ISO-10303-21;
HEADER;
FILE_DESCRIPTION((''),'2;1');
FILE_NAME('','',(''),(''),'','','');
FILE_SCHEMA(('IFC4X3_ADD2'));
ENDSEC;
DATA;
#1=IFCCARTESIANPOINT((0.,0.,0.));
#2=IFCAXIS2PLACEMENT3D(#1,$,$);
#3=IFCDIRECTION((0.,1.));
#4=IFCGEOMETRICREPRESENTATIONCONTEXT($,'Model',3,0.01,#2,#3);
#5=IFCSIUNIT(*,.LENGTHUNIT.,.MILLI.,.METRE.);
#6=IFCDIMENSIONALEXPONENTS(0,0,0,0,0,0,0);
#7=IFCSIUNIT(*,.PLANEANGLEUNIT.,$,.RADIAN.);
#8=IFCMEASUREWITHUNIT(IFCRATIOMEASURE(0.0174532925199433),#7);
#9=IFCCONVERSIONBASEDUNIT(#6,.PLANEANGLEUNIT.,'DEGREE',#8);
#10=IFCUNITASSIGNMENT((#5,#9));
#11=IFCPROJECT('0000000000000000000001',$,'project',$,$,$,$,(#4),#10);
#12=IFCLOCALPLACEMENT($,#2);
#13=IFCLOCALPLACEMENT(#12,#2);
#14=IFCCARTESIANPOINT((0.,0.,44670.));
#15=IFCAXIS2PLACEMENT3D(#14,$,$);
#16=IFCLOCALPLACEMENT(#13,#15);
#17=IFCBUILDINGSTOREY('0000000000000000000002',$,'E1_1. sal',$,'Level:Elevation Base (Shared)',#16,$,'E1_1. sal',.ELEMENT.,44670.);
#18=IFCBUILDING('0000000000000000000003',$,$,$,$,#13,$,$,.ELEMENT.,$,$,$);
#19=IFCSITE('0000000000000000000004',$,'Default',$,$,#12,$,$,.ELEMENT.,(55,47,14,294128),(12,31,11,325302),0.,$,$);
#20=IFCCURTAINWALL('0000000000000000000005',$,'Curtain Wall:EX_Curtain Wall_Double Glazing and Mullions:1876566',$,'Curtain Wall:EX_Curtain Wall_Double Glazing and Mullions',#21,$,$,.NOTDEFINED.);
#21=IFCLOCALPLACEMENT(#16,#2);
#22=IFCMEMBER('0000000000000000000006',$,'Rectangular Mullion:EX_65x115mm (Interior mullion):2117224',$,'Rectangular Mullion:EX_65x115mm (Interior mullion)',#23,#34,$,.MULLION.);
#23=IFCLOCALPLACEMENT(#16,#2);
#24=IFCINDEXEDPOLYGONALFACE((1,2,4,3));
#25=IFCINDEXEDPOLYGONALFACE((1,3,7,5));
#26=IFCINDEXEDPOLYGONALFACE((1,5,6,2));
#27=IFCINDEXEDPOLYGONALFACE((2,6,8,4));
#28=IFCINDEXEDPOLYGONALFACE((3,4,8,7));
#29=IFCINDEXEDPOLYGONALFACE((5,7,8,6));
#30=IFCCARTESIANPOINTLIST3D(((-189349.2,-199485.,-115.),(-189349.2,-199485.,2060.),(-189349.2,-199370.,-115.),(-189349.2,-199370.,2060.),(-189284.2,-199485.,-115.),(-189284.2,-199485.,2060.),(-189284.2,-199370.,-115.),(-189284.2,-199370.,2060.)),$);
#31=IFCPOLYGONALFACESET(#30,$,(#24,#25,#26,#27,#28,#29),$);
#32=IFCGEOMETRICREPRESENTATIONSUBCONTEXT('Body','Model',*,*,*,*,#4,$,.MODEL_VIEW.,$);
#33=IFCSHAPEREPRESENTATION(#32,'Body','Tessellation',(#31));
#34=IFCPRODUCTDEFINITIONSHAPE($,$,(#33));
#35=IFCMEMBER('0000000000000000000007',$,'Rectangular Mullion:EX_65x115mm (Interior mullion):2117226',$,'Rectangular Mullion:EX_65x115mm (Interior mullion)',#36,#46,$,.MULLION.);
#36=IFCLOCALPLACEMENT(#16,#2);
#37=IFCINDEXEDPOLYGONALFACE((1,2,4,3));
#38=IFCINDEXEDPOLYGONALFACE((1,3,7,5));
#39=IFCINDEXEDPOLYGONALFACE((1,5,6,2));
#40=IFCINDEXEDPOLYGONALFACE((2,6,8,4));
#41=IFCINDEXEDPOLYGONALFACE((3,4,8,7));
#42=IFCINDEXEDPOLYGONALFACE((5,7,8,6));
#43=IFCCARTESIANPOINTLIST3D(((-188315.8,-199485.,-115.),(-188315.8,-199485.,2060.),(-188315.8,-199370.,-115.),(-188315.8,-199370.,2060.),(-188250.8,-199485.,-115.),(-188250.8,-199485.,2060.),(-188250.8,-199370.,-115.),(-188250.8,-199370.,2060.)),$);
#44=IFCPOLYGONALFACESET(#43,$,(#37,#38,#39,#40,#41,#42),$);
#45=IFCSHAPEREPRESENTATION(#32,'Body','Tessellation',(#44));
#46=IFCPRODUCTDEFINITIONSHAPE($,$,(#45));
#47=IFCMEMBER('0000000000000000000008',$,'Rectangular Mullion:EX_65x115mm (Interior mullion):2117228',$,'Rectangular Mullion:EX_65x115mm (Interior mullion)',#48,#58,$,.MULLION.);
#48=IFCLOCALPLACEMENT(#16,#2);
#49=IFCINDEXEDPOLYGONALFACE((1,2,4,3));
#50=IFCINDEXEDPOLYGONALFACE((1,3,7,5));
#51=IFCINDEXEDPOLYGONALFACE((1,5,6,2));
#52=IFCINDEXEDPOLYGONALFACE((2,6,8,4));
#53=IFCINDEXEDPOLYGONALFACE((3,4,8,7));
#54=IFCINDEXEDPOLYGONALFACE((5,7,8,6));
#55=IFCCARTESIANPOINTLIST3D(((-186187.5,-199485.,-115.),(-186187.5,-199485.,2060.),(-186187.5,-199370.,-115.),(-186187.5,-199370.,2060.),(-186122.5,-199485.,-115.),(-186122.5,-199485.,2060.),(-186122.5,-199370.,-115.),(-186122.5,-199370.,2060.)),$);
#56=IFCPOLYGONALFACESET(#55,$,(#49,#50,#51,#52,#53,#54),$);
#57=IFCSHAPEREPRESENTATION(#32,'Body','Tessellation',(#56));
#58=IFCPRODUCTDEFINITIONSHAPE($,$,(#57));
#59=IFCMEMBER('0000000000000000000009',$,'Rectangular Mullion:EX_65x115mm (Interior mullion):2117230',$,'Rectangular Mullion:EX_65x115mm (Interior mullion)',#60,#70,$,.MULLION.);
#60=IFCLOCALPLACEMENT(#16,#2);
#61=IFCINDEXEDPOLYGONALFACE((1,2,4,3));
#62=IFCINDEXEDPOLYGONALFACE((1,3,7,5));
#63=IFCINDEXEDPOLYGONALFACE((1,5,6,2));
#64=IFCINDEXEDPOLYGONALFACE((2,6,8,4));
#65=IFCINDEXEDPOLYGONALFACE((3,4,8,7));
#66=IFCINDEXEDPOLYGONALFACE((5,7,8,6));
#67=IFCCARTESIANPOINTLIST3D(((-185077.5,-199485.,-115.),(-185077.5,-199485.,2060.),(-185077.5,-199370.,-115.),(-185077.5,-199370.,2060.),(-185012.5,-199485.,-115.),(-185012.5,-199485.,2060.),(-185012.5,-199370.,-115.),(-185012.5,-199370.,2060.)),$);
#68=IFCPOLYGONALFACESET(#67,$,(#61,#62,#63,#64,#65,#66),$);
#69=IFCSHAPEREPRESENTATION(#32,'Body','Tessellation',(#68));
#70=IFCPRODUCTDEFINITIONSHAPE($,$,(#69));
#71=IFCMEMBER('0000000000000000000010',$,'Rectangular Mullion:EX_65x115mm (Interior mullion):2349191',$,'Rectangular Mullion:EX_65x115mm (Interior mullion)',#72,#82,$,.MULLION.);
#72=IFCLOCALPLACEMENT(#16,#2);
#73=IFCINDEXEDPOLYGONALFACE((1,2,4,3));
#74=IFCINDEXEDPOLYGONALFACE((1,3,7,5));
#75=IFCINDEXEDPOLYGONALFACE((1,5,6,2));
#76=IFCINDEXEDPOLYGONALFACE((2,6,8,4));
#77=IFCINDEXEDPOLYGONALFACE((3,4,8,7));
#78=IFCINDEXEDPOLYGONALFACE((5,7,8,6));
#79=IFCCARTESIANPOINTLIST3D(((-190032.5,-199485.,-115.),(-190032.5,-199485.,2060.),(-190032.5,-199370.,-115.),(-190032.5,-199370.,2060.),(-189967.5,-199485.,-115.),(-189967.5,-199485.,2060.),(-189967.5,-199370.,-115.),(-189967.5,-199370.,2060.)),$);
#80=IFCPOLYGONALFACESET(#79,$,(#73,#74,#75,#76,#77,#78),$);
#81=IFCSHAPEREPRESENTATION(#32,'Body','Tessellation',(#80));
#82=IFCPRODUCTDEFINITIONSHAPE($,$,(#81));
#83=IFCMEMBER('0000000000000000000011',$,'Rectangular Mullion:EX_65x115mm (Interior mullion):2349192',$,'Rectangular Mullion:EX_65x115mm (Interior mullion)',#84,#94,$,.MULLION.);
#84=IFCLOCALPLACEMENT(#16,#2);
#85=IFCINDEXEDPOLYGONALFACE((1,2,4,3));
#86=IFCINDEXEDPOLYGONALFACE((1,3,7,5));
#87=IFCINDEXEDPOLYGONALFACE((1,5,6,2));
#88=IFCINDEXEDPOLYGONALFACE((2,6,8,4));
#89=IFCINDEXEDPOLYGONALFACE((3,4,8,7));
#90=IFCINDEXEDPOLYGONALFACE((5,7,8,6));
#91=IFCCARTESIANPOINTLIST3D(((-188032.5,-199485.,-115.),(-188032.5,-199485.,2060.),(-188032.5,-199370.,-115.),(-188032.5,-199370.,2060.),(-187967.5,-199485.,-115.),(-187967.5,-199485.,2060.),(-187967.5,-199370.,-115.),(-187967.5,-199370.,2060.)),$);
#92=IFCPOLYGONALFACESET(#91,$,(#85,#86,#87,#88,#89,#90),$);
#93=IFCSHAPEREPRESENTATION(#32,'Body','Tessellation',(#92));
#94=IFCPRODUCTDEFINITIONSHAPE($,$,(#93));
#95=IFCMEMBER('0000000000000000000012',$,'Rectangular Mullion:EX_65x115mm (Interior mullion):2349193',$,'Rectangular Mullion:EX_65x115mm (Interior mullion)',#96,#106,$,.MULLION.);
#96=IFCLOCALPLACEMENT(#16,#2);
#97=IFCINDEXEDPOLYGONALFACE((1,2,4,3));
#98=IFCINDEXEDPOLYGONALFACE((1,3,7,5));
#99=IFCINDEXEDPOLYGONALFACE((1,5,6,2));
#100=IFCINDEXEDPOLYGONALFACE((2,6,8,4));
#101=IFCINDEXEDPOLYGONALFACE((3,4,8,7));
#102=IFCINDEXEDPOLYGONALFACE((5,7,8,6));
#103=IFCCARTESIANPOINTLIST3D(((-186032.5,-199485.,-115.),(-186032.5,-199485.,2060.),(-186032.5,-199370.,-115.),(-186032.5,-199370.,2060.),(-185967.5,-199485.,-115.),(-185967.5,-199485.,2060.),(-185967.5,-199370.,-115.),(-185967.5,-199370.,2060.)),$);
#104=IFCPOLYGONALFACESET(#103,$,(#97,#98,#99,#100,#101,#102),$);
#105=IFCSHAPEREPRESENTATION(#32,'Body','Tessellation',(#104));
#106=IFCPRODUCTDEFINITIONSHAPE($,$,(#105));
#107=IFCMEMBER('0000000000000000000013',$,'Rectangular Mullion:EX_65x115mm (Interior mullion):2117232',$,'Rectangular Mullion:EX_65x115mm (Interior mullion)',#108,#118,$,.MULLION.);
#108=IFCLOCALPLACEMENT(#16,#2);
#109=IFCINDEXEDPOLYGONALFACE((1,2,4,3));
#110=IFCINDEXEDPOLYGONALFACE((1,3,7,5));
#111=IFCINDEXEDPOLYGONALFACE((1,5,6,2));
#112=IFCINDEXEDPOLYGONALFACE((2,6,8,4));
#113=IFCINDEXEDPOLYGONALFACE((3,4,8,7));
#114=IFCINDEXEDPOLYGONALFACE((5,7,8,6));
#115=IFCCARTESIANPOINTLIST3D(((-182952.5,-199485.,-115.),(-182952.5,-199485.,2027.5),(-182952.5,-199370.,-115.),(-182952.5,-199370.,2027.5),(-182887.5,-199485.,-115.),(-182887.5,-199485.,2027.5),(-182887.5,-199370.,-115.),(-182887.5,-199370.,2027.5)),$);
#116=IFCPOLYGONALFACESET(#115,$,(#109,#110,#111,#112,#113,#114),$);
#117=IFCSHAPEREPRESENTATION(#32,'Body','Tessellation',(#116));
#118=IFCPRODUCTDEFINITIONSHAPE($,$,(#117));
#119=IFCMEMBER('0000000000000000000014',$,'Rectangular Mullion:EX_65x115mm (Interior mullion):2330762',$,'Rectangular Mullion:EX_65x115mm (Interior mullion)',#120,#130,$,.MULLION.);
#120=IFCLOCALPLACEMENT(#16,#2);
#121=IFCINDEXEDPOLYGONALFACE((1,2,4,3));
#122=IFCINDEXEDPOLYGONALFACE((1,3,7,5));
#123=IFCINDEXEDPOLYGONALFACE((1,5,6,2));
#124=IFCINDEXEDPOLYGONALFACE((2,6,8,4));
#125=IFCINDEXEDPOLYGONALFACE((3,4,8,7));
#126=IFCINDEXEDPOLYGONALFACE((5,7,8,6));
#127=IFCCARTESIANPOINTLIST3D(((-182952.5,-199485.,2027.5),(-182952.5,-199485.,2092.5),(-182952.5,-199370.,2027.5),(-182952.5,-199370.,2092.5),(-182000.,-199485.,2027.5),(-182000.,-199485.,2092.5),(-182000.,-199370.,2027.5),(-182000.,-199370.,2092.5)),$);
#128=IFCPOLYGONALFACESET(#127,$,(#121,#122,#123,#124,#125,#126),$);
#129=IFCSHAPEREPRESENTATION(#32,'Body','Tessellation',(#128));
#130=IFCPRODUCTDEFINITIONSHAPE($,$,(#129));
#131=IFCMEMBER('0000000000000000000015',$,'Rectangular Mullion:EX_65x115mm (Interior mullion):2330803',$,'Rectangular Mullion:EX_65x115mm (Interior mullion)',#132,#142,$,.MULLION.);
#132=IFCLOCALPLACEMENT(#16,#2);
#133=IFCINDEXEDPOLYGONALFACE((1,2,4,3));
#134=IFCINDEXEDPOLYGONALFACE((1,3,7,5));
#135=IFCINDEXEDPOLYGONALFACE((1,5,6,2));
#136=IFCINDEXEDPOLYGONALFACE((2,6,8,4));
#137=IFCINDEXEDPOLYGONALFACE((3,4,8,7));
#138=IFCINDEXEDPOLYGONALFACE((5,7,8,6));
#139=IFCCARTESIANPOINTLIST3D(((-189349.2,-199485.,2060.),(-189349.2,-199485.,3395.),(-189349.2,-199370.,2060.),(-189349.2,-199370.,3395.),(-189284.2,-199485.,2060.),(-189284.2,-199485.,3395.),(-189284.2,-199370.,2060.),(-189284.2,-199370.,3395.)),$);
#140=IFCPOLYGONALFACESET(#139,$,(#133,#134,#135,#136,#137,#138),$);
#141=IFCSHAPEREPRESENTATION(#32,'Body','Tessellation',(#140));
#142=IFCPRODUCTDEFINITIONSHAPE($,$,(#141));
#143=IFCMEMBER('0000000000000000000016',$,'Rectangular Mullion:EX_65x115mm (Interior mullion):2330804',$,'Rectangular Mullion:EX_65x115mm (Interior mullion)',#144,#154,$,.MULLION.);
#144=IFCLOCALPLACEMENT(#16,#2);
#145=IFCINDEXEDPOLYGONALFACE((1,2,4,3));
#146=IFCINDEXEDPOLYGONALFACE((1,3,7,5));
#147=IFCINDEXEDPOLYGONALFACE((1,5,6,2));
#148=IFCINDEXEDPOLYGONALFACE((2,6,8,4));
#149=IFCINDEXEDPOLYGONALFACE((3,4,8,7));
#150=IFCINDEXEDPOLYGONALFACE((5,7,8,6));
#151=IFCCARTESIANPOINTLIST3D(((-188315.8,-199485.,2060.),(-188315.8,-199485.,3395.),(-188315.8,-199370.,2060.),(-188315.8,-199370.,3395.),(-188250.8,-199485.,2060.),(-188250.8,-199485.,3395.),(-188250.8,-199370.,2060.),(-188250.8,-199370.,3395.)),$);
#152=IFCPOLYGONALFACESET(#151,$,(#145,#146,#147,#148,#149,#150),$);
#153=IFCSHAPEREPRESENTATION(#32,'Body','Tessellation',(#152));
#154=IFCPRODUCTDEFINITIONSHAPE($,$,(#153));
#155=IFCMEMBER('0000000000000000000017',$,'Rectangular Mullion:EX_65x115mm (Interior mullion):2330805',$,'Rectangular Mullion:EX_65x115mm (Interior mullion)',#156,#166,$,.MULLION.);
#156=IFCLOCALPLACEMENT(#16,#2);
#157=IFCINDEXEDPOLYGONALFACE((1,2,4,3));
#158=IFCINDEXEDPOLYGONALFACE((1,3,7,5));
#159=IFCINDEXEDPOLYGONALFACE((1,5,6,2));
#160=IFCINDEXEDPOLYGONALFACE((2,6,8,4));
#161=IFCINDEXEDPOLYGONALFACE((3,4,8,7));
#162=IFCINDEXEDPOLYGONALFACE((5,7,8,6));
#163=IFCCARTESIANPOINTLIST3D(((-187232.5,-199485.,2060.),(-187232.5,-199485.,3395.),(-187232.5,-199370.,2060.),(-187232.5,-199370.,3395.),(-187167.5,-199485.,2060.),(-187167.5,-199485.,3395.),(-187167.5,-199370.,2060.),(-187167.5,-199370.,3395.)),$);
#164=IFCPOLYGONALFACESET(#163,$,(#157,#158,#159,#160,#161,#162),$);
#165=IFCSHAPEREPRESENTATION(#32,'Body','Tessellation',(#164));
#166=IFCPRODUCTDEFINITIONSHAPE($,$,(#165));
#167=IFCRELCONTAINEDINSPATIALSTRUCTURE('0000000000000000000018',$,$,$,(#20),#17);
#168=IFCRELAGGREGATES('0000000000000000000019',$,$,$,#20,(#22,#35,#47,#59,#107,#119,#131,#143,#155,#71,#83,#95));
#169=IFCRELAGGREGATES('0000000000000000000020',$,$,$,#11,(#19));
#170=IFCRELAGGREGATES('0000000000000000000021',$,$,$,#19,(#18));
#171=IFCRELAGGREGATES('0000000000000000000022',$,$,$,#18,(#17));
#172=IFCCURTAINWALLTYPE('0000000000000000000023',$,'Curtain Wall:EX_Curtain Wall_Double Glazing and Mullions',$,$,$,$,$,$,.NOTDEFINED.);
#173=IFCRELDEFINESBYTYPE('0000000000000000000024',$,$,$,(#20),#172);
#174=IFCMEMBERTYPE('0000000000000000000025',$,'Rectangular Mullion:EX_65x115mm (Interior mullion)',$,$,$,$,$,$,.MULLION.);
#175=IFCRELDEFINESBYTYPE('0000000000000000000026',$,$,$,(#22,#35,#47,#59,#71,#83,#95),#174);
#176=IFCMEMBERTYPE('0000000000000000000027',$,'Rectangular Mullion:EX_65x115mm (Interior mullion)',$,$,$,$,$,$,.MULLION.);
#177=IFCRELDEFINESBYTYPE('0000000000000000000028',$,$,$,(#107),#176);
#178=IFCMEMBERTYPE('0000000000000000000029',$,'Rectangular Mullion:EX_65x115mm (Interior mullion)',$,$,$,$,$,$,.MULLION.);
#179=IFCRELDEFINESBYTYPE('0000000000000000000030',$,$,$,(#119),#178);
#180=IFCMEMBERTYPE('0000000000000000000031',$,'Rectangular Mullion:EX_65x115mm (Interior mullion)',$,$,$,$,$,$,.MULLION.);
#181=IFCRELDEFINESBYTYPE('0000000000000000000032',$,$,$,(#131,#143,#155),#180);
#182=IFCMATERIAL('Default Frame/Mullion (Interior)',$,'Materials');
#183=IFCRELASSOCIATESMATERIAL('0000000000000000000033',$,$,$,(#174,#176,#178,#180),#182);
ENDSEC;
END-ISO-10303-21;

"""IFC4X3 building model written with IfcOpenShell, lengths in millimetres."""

from ifc_helpers import new_model, entity, si_unit, converted_unit, direction, frame, origin, origin_2d_with_axis, place, context, subcontext, project, spatial, rectangle, extrude, source, transform, mapped, material, material_profile, profile_set, type_object, type_shapes, element, aggregate, save


model = new_model("IFC4X3")

# Units and contexts
model_context = context("Model", 3, precision=0.01, world=origin(), true_north=direction((0.0, 1.0)))
body_context = subcontext(model_context, "Body", "Model", "MODEL_VIEW")
ifc_project = project(units=[si_unit("LENGTHUNIT", "METRE", prefix="MILLI"), converted_unit("PLANEANGLEUNIT", "DEGREE", entity("IfcRatioMeasure", 0.0174532925199433), si_unit("PLANEANGLEUNIT", "RADIAN"), dimensions=[0, 0, 0, 0, 0, 0, 0])], contexts=[model_context])

# Site, building, storey
site_placement = place(None, origin())
site = spatial("IfcSite", under=ifc_project, at=site_placement, Name="Default", CompositionType="ELEMENT", RefLatitude=(55, 47, 14, 294128), RefLongitude=(12, 31, 11, 325302), RefElevation=0.0)
building_placement = place(site_placement, origin())
building = spatial("IfcBuilding", under=site, at=building_placement, CompositionType="ELEMENT")
storey_placement = place(building_placement, frame((0.0, 0.0, 44670.0)))
storey = spatial("IfcBuildingStorey", under=building, at=storey_placement, Name="E1_1. sal", ObjectType="Level:Elevation Base (Shared)", LongName="E1_1. sal", CompositionType="ELEMENT", Elevation=44670.0)

# Curtain wall, members
curtain_wall_type = type_object("IfcCurtainWallType", Name="Curtain Wall:EX_Curtain Wall_Double Glazing and Mullions", PredefinedType="NOTDEFINED")
curtain_wall_placement = place(storey_placement, frame((0.0, 0.0, -44670.0)))
curtain_wall = element("IfcCurtainWall", 1, at=curtain_wall_placement, inside=storey, type_object=curtain_wall_type, Name="Curtain Wall:EX_Curtain Wall_Double Glazing and Mullions:1876566", ObjectType="Curtain Wall:EX_Curtain Wall_Double Glazing and Mullions", PredefinedType="NOTDEFINED")
ifc_material_1 = material(Name="Default Frame/Mullion (Interior)", Category="Materials")
ifc_material_profile_1 = material_profile(ifc_material_1, rectangle(XDim=115.0, YDim=65.0, at=origin_2d_with_axis()), Name="EX_65x115mm (Interior mullion)")
ifc_profile_set_1 = profile_set([ifc_material_profile_1], Name="EX_65x115mm (Interior mullion)")
member_type_1 = type_object("IfcMemberType", Name="Rectangular Mullion:EX_65x115mm (Interior mullion)", PredefinedType="MULLION", material=ifc_profile_set_1)
shared_shape_1 = source(origin(), body_context, "Body", "SweptSolid", [
    extrude(rectangle(XDim=115.0, YDim=65.0, at=origin_2d_with_axis()), frame((0.0, -57.5, -2175.0), z_axis=(0.0, 0.0, 1.0), x_axis=(0.0, -1.0, 0.0)), (0.0, 0.0, 1.0), 2175.0),
])
type_shapes(member_type_1, [shared_shape_1])
member_1_placement = place(curtain_wall_placement, frame((-189316.7, -199485.0, 44555.0), z_axis=(0.0, 0.0, -1.0), x_axis=(1.0, 0.0, 0.0)))
member_1 = element("IfcMember", 2, at=member_1_placement, type_object=member_type_1, Name="Rectangular Mullion:EX_65x115mm (Interior mullion):2117224", ObjectType="Rectangular Mullion:EX_65x115mm (Interior mullion)", PredefinedType="MULLION", context=body_context, shape_type="MappedRepresentation", body=[
    mapped(shared_shape_1, transform((0.0, 0.0, 0.0), scale=1.0)),
])
member_2_placement = place(curtain_wall_placement, frame((-188283.3, -199485.0, 44555.0), z_axis=(0.0, 0.0, -1.0), x_axis=(1.0, 0.0, 0.0)))
member_2 = element("IfcMember", 3, at=member_2_placement, type_object=member_type_1, Name="Rectangular Mullion:EX_65x115mm (Interior mullion):2117226", ObjectType="Rectangular Mullion:EX_65x115mm (Interior mullion)", PredefinedType="MULLION", context=body_context, shape_type="MappedRepresentation", body=[
    mapped(shared_shape_1, transform((0.0, 0.0, 0.0), scale=1.0)),
])
member_3_placement = place(curtain_wall_placement, frame((-186155.0, -199485.0, 44555.0), z_axis=(0.0, 0.0, -1.0), x_axis=(1.0, 0.0, 0.0)))
member_3 = element("IfcMember", 4, at=member_3_placement, type_object=member_type_1, Name="Rectangular Mullion:EX_65x115mm (Interior mullion):2117228", ObjectType="Rectangular Mullion:EX_65x115mm (Interior mullion)", PredefinedType="MULLION", context=body_context, shape_type="MappedRepresentation", body=[
    mapped(shared_shape_1, transform((0.0, 0.0, 0.0), scale=1.0)),
])
member_4_placement = place(curtain_wall_placement, frame((-185045.0, -199485.0, 44555.0), z_axis=(0.0, 0.0, -1.0), x_axis=(1.0, 0.0, 0.0)))
member_4 = element("IfcMember", 5, at=member_4_placement, type_object=member_type_1, Name="Rectangular Mullion:EX_65x115mm (Interior mullion):2117230", ObjectType="Rectangular Mullion:EX_65x115mm (Interior mullion)", PredefinedType="MULLION", context=body_context, shape_type="MappedRepresentation", body=[
    mapped(shared_shape_1, transform((0.0, 0.0, 0.0), scale=1.0)),
])
member_5_placement = place(curtain_wall_placement, frame((-190000.0, -199485.0, 44555.0), z_axis=(0.0, 0.0, -1.0), x_axis=(1.0, 0.0, 0.0)))
member_5 = element("IfcMember", 6, at=member_5_placement, type_object=member_type_1, Name="Rectangular Mullion:EX_65x115mm (Interior mullion):2349191", ObjectType="Rectangular Mullion:EX_65x115mm (Interior mullion)", PredefinedType="MULLION", context=body_context, shape_type="MappedRepresentation", body=[
    mapped(shared_shape_1, transform((0.0, 0.0, 0.0), scale=1.0)),
])
member_6_placement = place(curtain_wall_placement, frame((-188000.0, -199485.0, 44555.0), z_axis=(0.0, 0.0, -1.0), x_axis=(1.0, 0.0, 0.0)))
member_6 = element("IfcMember", 7, at=member_6_placement, type_object=member_type_1, Name="Rectangular Mullion:EX_65x115mm (Interior mullion):2349192", ObjectType="Rectangular Mullion:EX_65x115mm (Interior mullion)", PredefinedType="MULLION", context=body_context, shape_type="MappedRepresentation", body=[
    mapped(shared_shape_1, transform((0.0, 0.0, 0.0), scale=1.0)),
])
member_7_placement = place(curtain_wall_placement, frame((-186000.0, -199485.0, 44555.0), z_axis=(0.0, 0.0, -1.0), x_axis=(1.0, 0.0, 0.0)))
member_7 = element("IfcMember", 8, at=member_7_placement, type_object=member_type_1, Name="Rectangular Mullion:EX_65x115mm (Interior mullion):2349193", ObjectType="Rectangular Mullion:EX_65x115mm (Interior mullion)", PredefinedType="MULLION", context=body_context, shape_type="MappedRepresentation", body=[
    mapped(shared_shape_1, transform((0.0, 0.0, 0.0), scale=1.0)),
])
member_type_2 = type_object("IfcMemberType", Name="Rectangular Mullion:EX_65x115mm (Interior mullion)", PredefinedType="MULLION", material=ifc_profile_set_1)
shared_shape_2 = source(origin(), body_context, "Body", "SweptSolid", [
    extrude(rectangle(XDim=115.0, YDim=65.0, at=origin_2d_with_axis()), frame((0.0, -57.5, -2142.5), z_axis=(0.0, 0.0, 1.0), x_axis=(0.0, -1.0, 0.0)), (0.0, 0.0, 1.0), 2142.5),
])
type_shapes(member_type_2, [shared_shape_2])
member_8_placement = place(curtain_wall_placement, frame((-182920.0, -199485.0, 44555.0), z_axis=(0.0, 0.0, -1.0), x_axis=(1.0, 0.0, 0.0)))
member_8 = element("IfcMember", 9, at=member_8_placement, type_object=member_type_2, Name="Rectangular Mullion:EX_65x115mm (Interior mullion):2117232", ObjectType="Rectangular Mullion:EX_65x115mm (Interior mullion)", PredefinedType="MULLION", context=body_context, shape_type="MappedRepresentation", body=[
    mapped(shared_shape_2, transform((0.0, 0.0, 0.0), scale=1.0)),
])
member_type_3 = type_object("IfcMemberType", Name="Rectangular Mullion:EX_65x115mm (Interior mullion)", PredefinedType="MULLION", material=ifc_profile_set_1)
shared_shape_3 = source(origin(), body_context, "Body", "SweptSolid", [
    extrude(rectangle(XDim=115.0, YDim=65.0, at=origin_2d_with_axis()), frame((0.0, -57.5, -952.5), z_axis=(0.0, 0.0, 1.0), x_axis=(0.0, -1.0, 0.0)), (0.0, 0.0, 1.0), 952.5),
])
type_shapes(member_type_3, [shared_shape_3])
member_9_placement = place(curtain_wall_placement, frame((-182000.0, -199485.0, 46730.0), z_axis=(1.0, 0.0, 0.0), x_axis=(0.0, 0.0, 1.0)))
member_9 = element("IfcMember", 10, at=member_9_placement, type_object=member_type_3, Name="Rectangular Mullion:EX_65x115mm (Interior mullion):2330762", ObjectType="Rectangular Mullion:EX_65x115mm (Interior mullion)", PredefinedType="MULLION", context=body_context, shape_type="MappedRepresentation", body=[
    mapped(shared_shape_3, transform((0.0, 0.0, 0.0), scale=1.0)),
])
member_type_4 = type_object("IfcMemberType", Name="Rectangular Mullion:EX_65x115mm (Interior mullion)", PredefinedType="MULLION", material=ifc_profile_set_1)
shared_shape_4 = source(origin(), body_context, "Body", "SweptSolid", [
    extrude(rectangle(XDim=115.0, YDim=65.0, at=origin_2d_with_axis()), frame((0.0, -57.5, -1335.0), z_axis=(0.0, 0.0, 1.0), x_axis=(0.0, -1.0, 0.0)), (0.0, 0.0, 1.0), 1335.0),
])
type_shapes(member_type_4, [shared_shape_4])
member_10_placement = place(curtain_wall_placement, frame((-189316.7, -199485.0, 46730.0), z_axis=(0.0, 0.0, -1.0), x_axis=(1.0, 0.0, 0.0)))
member_10 = element("IfcMember", 11, at=member_10_placement, type_object=member_type_4, Name="Rectangular Mullion:EX_65x115mm (Interior mullion):2330803", ObjectType="Rectangular Mullion:EX_65x115mm (Interior mullion)", PredefinedType="MULLION", context=body_context, shape_type="MappedRepresentation", body=[
    mapped(shared_shape_4, transform((0.0, 0.0, 0.0), scale=1.0)),
])
member_11_placement = place(curtain_wall_placement, frame((-188283.3, -199485.0, 46730.0), z_axis=(0.0, 0.0, -1.0), x_axis=(1.0, 0.0, 0.0)))
member_11 = element("IfcMember", 12, at=member_11_placement, type_object=member_type_4, Name="Rectangular Mullion:EX_65x115mm (Interior mullion):2330804", ObjectType="Rectangular Mullion:EX_65x115mm (Interior mullion)", PredefinedType="MULLION", context=body_context, shape_type="MappedRepresentation", body=[
    mapped(shared_shape_4, transform((0.0, 0.0, 0.0), scale=1.0)),
])
member_12_placement = place(curtain_wall_placement, frame((-187200.0, -199485.0, 46730.0), z_axis=(0.0, 0.0, -1.0), x_axis=(1.0, 0.0, 0.0)))
member_12 = element("IfcMember", 13, at=member_12_placement, type_object=member_type_4, Name="Rectangular Mullion:EX_65x115mm (Interior mullion):2330805", ObjectType="Rectangular Mullion:EX_65x115mm (Interior mullion)", PredefinedType="MULLION", context=body_context, shape_type="MappedRepresentation", body=[
    mapped(shared_shape_4, transform((0.0, 0.0, 0.0), scale=1.0)),
])
aggregate(curtain_wall, [member_1, member_2, member_3, member_4, member_8, member_9, member_10, member_11, member_12, member_5, member_6, member_7])

save(model, "model.ifc")
